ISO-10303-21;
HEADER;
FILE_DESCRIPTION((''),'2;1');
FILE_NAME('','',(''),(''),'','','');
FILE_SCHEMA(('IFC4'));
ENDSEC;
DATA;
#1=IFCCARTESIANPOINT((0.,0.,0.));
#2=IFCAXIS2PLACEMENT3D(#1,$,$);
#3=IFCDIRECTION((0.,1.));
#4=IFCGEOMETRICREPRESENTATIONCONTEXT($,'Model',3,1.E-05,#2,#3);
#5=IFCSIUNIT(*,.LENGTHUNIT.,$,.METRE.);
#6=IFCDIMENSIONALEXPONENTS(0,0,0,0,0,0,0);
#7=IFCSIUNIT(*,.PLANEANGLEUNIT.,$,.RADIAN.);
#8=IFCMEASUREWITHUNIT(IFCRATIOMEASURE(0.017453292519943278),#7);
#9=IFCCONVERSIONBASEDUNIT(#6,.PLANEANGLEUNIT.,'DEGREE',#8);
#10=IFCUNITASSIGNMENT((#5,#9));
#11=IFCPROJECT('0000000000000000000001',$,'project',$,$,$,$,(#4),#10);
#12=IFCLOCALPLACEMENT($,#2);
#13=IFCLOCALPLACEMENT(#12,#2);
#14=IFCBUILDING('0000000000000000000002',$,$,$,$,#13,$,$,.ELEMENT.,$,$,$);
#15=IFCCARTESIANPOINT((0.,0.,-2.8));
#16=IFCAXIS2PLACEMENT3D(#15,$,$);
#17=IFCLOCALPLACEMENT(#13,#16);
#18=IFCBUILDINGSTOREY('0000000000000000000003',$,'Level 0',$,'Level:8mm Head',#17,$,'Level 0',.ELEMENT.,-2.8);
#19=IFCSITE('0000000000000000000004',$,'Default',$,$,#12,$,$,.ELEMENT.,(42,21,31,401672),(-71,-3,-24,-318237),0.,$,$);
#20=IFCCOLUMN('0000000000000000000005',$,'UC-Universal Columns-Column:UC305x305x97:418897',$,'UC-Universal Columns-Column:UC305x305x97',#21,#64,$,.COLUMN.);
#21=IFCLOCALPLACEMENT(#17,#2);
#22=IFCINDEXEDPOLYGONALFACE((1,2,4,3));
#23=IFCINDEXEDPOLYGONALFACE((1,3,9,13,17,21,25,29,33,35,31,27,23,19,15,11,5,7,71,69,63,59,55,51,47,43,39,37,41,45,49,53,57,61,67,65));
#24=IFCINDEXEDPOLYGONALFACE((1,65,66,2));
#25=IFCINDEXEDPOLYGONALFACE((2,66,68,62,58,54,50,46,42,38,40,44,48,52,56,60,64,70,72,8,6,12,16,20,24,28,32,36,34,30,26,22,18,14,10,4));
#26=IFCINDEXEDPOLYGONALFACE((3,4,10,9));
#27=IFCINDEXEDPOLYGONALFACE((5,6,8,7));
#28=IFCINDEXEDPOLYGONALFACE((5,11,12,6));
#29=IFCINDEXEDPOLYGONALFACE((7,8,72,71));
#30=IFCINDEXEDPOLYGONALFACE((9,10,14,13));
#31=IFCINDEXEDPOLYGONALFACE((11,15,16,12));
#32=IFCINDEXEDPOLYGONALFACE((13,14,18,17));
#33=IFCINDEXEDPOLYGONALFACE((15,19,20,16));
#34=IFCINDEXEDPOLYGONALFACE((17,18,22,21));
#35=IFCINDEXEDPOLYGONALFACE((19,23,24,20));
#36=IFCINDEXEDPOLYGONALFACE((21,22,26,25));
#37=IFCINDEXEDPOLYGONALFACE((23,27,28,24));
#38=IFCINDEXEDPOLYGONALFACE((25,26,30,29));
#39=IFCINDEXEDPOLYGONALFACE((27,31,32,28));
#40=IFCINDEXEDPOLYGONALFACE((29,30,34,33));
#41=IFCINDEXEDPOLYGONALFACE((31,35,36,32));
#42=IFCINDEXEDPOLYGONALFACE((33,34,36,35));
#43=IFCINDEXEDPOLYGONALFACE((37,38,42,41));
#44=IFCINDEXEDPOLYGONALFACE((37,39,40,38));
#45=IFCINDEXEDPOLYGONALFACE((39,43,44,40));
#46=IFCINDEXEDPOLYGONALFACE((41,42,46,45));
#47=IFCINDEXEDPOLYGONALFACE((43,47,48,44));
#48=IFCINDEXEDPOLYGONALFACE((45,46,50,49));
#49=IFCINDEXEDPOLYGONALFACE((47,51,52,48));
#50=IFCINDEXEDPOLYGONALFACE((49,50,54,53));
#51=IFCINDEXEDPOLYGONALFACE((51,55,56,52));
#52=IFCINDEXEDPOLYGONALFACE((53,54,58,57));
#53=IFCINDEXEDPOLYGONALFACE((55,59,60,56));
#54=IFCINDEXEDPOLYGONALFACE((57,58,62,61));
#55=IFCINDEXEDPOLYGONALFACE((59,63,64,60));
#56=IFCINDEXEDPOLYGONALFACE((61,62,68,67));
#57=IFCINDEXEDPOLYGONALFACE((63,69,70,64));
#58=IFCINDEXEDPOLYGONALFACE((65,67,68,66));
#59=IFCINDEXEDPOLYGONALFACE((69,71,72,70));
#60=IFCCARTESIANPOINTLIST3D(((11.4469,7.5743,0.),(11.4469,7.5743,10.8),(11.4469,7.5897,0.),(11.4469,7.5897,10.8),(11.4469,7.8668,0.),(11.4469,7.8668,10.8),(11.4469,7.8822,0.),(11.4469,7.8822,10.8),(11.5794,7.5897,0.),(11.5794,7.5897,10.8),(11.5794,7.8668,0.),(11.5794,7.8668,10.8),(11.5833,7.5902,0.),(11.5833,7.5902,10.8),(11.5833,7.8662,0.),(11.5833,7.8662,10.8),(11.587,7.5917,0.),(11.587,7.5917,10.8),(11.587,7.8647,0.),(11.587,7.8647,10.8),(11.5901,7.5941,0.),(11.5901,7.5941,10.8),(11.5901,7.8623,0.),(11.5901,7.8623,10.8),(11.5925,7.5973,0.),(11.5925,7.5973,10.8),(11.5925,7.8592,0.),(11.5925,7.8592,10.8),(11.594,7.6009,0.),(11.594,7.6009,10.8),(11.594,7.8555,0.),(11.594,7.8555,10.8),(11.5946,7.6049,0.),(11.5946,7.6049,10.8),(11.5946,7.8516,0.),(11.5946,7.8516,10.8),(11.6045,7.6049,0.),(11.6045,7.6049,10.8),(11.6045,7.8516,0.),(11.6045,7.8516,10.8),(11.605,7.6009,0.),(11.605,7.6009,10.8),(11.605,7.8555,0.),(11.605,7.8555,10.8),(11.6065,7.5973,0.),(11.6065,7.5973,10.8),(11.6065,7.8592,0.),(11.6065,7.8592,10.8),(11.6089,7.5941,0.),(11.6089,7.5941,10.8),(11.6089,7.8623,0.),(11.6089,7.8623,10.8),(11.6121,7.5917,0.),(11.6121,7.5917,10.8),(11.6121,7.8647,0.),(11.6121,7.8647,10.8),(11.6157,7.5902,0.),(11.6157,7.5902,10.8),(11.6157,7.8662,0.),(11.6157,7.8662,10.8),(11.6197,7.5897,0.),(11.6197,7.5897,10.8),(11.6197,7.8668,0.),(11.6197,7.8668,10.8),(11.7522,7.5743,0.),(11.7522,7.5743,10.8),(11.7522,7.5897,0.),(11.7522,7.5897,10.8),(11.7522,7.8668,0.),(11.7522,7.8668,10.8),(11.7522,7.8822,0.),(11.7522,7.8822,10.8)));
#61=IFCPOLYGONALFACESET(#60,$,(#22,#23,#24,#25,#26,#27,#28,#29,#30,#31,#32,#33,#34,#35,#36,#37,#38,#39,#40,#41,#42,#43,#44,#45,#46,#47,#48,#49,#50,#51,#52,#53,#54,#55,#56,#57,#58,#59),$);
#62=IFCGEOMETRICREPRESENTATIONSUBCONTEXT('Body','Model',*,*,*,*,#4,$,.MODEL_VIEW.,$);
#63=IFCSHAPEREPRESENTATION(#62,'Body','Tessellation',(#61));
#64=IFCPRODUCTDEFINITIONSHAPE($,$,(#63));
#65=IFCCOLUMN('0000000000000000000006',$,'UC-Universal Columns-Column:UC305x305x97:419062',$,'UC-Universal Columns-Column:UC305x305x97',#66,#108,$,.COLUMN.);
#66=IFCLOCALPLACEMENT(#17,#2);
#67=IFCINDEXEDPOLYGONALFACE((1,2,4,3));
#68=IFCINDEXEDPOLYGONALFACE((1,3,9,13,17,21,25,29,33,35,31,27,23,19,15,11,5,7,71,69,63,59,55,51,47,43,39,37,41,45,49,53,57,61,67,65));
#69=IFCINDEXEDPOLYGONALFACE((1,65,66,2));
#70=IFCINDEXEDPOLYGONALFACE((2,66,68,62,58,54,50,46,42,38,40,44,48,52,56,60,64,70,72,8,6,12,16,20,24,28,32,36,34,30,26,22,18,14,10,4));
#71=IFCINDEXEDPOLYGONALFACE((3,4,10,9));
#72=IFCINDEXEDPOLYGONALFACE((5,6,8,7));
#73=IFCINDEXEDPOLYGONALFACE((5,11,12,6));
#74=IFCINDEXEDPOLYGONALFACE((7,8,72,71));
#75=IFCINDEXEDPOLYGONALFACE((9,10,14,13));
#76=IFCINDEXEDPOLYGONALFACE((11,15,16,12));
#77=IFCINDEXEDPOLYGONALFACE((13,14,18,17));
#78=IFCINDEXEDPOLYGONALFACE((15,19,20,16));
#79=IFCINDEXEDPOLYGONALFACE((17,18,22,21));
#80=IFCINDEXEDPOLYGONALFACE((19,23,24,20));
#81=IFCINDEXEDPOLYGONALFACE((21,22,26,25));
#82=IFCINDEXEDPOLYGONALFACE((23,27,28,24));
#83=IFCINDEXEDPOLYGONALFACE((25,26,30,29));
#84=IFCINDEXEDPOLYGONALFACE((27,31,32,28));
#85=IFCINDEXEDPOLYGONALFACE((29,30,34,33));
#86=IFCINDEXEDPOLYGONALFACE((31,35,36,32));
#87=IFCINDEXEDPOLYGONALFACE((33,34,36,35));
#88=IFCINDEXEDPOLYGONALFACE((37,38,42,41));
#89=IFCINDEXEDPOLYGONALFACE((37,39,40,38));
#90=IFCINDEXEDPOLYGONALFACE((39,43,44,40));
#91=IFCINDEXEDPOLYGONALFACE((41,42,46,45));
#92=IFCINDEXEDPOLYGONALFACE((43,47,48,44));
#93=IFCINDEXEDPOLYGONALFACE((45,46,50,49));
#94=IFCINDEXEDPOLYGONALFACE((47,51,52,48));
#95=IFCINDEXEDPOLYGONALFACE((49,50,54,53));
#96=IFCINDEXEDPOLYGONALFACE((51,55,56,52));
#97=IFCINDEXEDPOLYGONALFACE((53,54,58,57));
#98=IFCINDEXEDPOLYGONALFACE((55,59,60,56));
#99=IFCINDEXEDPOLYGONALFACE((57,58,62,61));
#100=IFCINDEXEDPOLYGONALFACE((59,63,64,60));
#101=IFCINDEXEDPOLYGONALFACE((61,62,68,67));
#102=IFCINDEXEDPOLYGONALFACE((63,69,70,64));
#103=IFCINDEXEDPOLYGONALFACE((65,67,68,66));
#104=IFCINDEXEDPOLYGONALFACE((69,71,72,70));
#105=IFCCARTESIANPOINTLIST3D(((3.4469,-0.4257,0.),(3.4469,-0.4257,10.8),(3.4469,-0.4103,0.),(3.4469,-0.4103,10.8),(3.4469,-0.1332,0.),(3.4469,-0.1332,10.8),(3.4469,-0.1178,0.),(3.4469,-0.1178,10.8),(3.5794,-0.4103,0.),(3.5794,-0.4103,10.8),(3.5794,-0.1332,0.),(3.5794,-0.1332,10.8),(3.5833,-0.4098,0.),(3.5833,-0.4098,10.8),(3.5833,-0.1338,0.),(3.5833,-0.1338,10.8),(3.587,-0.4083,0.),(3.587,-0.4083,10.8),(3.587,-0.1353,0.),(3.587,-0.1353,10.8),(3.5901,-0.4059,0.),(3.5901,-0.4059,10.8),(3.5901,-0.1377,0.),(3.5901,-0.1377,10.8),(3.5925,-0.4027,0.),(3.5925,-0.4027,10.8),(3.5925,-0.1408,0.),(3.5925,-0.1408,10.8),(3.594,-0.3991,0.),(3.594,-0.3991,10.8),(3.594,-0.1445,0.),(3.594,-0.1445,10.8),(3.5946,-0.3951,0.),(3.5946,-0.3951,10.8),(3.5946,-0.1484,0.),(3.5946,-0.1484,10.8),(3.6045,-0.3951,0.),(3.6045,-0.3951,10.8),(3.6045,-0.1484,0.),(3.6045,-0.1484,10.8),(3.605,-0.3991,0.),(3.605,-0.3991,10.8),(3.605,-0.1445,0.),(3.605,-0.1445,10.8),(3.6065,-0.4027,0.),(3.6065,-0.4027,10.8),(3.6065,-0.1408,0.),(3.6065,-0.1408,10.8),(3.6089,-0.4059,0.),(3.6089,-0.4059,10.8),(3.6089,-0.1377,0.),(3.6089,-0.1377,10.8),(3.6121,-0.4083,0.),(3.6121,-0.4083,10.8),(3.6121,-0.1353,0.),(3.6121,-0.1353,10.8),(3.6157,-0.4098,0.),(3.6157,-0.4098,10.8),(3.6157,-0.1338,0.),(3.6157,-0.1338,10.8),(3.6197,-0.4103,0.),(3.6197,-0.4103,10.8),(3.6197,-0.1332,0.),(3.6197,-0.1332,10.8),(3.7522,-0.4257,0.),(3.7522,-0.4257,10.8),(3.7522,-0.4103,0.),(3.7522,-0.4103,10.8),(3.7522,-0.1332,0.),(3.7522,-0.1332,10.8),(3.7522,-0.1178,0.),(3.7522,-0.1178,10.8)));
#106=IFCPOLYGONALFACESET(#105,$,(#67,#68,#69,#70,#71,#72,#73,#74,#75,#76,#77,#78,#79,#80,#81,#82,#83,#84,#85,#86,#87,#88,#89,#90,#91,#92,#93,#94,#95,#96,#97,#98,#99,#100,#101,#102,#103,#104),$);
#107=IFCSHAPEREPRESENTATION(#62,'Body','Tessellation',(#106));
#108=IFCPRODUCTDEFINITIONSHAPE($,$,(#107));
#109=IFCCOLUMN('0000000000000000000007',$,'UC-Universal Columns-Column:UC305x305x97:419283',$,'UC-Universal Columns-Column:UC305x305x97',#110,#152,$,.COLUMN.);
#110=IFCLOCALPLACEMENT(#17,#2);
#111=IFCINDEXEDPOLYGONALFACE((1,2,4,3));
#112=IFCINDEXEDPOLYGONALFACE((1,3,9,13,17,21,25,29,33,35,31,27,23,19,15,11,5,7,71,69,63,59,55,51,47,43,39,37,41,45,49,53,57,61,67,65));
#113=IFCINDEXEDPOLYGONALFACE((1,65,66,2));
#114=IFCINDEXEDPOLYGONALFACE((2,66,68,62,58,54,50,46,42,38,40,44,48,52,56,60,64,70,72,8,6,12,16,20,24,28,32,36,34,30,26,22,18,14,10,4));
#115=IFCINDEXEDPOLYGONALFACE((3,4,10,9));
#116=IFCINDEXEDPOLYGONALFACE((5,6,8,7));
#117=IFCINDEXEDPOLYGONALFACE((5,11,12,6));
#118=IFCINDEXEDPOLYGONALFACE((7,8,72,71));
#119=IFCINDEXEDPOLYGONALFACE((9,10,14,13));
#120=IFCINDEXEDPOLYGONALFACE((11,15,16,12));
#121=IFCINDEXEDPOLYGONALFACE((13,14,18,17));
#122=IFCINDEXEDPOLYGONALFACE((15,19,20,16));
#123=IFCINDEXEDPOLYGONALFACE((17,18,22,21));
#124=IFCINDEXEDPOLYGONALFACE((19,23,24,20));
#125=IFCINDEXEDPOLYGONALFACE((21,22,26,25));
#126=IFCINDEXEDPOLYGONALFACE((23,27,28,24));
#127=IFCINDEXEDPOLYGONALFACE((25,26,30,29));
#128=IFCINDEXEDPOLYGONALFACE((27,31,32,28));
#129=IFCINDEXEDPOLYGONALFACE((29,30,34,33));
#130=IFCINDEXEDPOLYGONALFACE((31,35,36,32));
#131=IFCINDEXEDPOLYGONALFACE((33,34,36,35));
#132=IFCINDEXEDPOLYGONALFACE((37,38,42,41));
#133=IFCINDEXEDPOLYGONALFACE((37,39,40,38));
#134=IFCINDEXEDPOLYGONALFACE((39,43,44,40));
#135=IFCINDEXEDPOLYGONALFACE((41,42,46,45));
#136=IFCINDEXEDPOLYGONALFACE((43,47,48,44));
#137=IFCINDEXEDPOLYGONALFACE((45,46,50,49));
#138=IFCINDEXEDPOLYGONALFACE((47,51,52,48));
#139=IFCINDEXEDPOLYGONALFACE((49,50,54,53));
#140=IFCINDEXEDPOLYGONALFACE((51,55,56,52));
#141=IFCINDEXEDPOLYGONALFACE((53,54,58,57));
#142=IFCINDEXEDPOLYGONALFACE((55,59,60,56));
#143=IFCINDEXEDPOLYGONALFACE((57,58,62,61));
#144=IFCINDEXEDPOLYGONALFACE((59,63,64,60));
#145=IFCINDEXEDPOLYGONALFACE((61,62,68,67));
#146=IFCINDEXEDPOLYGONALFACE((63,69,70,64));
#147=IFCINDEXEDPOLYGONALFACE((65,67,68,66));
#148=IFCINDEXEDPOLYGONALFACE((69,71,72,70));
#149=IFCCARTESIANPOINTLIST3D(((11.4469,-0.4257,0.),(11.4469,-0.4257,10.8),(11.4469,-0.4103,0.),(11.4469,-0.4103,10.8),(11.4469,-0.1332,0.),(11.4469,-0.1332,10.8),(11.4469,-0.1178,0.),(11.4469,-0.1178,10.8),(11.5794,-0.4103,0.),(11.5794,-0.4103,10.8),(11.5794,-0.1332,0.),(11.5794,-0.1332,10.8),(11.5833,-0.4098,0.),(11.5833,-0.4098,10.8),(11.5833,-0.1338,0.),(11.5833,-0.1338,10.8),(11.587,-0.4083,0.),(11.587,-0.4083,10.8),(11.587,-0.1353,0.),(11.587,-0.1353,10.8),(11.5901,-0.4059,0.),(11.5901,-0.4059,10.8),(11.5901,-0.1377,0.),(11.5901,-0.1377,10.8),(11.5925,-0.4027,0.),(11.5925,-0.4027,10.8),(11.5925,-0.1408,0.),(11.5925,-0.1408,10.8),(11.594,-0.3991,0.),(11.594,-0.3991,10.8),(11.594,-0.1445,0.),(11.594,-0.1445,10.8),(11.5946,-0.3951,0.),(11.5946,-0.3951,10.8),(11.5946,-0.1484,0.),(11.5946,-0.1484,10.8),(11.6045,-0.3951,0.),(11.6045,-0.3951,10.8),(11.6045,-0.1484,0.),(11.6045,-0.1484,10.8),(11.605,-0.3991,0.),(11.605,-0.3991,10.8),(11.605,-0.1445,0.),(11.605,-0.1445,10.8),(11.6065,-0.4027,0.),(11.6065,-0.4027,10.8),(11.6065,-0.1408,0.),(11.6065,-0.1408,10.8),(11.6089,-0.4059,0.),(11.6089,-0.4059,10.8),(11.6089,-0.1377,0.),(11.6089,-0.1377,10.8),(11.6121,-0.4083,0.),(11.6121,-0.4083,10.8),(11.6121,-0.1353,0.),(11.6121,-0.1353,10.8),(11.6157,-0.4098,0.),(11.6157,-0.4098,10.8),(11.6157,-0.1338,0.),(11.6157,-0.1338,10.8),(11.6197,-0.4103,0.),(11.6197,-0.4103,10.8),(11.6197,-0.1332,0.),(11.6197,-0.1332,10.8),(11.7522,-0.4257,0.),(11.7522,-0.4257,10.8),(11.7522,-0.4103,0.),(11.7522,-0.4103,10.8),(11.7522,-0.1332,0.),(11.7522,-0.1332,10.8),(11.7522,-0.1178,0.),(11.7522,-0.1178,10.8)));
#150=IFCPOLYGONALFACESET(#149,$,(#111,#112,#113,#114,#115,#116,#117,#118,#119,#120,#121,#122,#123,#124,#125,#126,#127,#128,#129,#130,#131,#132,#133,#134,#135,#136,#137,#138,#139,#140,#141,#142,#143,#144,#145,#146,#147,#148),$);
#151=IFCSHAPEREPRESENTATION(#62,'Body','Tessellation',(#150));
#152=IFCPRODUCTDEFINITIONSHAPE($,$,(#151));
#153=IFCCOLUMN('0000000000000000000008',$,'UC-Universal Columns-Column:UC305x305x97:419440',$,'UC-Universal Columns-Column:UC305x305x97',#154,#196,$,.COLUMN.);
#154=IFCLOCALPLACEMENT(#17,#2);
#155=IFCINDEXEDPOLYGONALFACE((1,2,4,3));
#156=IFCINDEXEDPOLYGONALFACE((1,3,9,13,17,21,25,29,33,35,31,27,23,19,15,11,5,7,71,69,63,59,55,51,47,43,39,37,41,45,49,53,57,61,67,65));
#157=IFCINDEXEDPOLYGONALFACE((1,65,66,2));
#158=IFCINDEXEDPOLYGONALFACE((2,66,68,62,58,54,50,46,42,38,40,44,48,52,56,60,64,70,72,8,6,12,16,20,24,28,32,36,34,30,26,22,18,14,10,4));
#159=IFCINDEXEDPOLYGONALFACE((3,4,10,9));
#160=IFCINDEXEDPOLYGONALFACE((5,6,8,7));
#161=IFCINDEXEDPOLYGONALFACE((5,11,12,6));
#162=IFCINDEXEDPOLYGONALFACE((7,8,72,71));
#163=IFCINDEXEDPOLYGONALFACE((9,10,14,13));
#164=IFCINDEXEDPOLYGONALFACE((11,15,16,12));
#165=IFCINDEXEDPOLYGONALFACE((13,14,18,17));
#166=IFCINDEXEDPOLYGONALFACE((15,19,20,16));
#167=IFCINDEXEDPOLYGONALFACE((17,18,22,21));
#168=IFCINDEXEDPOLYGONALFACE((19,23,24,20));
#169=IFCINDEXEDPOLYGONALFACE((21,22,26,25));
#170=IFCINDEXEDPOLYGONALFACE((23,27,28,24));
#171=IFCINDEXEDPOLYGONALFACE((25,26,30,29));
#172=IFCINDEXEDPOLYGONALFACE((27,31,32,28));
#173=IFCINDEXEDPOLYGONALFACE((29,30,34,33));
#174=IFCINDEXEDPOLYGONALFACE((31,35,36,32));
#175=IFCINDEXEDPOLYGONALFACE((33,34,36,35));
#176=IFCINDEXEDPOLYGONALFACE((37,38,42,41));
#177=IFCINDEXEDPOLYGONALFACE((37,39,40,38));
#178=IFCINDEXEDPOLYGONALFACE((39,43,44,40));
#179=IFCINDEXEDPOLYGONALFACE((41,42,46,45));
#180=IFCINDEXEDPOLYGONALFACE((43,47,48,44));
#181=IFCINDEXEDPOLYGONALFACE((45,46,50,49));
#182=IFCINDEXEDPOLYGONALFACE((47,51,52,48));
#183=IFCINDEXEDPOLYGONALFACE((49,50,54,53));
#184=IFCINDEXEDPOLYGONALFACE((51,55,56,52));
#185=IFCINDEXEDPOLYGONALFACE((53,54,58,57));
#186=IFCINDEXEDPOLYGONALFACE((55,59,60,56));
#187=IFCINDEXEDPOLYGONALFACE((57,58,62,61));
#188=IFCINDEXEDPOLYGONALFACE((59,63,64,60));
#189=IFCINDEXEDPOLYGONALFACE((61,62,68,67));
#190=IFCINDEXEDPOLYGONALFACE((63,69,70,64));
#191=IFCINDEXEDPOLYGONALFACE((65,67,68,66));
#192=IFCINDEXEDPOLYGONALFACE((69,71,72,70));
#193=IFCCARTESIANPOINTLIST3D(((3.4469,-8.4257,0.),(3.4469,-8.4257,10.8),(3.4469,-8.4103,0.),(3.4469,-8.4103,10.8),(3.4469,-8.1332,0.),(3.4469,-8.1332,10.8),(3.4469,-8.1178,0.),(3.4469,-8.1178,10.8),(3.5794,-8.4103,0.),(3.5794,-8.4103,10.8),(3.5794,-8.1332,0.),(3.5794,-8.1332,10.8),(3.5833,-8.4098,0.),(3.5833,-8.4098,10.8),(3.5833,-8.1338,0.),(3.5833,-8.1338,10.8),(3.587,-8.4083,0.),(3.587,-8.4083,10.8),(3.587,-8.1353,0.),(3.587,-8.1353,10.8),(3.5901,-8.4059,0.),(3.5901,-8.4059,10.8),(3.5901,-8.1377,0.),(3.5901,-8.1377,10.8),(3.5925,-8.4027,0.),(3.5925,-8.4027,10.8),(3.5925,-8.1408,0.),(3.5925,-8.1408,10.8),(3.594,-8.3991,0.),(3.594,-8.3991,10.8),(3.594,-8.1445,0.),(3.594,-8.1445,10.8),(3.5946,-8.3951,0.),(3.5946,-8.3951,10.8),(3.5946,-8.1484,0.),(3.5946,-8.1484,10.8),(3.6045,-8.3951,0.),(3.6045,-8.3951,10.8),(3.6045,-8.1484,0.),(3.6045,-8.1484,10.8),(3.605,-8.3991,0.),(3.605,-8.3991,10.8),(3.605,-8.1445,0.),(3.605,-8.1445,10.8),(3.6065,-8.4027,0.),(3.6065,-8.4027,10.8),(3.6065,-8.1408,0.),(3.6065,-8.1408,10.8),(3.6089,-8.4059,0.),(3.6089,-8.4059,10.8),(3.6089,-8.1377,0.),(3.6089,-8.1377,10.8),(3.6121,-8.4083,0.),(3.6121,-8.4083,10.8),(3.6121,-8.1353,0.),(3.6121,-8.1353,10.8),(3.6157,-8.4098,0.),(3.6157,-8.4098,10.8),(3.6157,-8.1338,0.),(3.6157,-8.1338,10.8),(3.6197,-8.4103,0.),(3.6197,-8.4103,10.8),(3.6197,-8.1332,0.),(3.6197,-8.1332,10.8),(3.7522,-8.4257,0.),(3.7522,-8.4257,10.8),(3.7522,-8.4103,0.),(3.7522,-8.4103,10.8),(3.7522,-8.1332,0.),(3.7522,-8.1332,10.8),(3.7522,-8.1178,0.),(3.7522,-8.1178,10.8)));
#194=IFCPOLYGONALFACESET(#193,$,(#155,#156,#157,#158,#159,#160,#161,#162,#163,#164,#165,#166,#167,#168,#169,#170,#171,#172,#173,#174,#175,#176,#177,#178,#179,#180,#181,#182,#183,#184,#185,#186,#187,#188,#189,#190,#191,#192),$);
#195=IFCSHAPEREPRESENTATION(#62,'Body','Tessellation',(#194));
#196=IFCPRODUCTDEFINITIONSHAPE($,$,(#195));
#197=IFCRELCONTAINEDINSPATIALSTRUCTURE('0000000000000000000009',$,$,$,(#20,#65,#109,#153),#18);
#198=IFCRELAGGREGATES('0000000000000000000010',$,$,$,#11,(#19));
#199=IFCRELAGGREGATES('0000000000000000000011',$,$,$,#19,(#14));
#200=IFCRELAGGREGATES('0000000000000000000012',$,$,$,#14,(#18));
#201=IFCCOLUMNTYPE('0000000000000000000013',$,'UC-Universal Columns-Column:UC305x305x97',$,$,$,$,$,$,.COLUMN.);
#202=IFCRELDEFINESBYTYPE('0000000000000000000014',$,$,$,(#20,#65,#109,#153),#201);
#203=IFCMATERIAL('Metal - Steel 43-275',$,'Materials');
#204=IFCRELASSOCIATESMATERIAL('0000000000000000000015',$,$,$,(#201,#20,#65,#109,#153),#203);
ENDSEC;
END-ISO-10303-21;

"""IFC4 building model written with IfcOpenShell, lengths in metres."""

from ifc_helpers import new_model, entity, si_unit, converted_unit, direction, frame, origin, place, context, subcontext, project, spatial, line, arc, indexed_curve, outline, extrude, source, transform, mapped, material, type_object, type_shapes, element, save


model = new_model("IFC4")

# Units and contexts
model_context = context("Model", 3, precision=1e-05, world=origin(), true_north=direction((0.0, 1.0)))
body_context = subcontext(model_context, "Body", "Model", "MODEL_VIEW")
ifc_project = project(units=[si_unit("LENGTHUNIT", "METRE"), converted_unit("PLANEANGLEUNIT", "DEGREE", entity("IfcRatioMeasure", 0.017453292519943278), si_unit("PLANEANGLEUNIT", "RADIAN"), dimensions=[0, 0, 0, 0, 0, 0, 0])], contexts=[model_context])

# Site, building, storey
site_placement = place(None, origin())
site = spatial("IfcSite", under=ifc_project, at=site_placement, Name="Default", CompositionType="ELEMENT", RefLatitude=(42, 21, 31, 401672), RefLongitude=(-71, -3, -24, -318237), RefElevation=0.0)
building_placement = place(site_placement, origin())
building = spatial("IfcBuilding", under=site, at=building_placement, CompositionType="ELEMENT")
storey_placement = place(building_placement, frame((0.0, 0.0, -2.8)))
storey = spatial("IfcBuildingStorey", under=building, at=storey_placement, Name="Level 0", ObjectType="Level:8mm Head", LongName="Level 0", CompositionType="ELEMENT", Elevation=-2.8)

# Columns
ifc_material_1 = material(Name="Metal - Steel 43-275", Category="Materials")
column_type = type_object("IfcColumnType", Name="UC-Universal Columns-Column:UC305x305x97", PredefinedType="COLUMN", material=ifc_material_1)
shared_shape = source(origin(), body_context, "Body", "SweptSolid", [
    extrude(outline(indexed_curve([(-0.154, -0.1526), (-0.1385, -0.1526), (-0.1385, -0.0202), (-0.1341, -0.0094), (-0.1234, -0.0049), (0.1233, -0.0049), (0.1341, -0.0094), (0.1385, -0.0201), (0.1385, -0.1526), (0.154, -0.1526), (0.154, 0.1526), (0.1385, 0.1526), (0.1385, 0.0202), (0.1341, 0.0094), (0.1234, 0.005), (-0.1233, 0.005), (-0.1341, 0.0094), (-0.1385, 0.0202), (-0.1385, 0.1526), (-0.154, 0.1526)], segments=[line(1, 2, 3), arc(3, 4, 5), line(5, 6), arc(6, 7, 8), line(8, 9, 10, 11, 12, 13), arc(13, 14, 15), line(15, 16), arc(16, 17, 18), line(18, 19, 20, 1)], self_intersect=False)), frame((0.0, 0.0, -2.8), z_axis=(0.0, 0.0, 1.0), x_axis=(0.0, -1.0, 0.0)), (0.0, 0.0, 1.0), 10.8),
])
type_shapes(column_type, [shared_shape])
for number, where, name in (
    (1, (11.5995, 7.7282, 2.8), "UC-Universal Columns-Column:UC305x305x97:418897"),
    (2, (3.5995, -0.2718, 2.8), "UC-Universal Columns-Column:UC305x305x97:419062"),
    (3, (11.5995, -0.2718, 2.8), "UC-Universal Columns-Column:UC305x305x97:419283"),
    (4, (3.5995, -8.2718, 2.8), "UC-Universal Columns-Column:UC305x305x97:419440"),
):
    element("IfcColumn", number, at=place(storey_placement, frame(where)), inside=storey, type_object=column_type, material=ifc_material_1, Name=name, ObjectType="UC-Universal Columns-Column:UC305x305x97", PredefinedType="COLUMN", context=body_context, shape_type="MappedRepresentation", body=[
        mapped(shared_shape, transform((0.0, 0.0, 0.0), scale=1.0)),
    ])

save(model, "model.ifc")
